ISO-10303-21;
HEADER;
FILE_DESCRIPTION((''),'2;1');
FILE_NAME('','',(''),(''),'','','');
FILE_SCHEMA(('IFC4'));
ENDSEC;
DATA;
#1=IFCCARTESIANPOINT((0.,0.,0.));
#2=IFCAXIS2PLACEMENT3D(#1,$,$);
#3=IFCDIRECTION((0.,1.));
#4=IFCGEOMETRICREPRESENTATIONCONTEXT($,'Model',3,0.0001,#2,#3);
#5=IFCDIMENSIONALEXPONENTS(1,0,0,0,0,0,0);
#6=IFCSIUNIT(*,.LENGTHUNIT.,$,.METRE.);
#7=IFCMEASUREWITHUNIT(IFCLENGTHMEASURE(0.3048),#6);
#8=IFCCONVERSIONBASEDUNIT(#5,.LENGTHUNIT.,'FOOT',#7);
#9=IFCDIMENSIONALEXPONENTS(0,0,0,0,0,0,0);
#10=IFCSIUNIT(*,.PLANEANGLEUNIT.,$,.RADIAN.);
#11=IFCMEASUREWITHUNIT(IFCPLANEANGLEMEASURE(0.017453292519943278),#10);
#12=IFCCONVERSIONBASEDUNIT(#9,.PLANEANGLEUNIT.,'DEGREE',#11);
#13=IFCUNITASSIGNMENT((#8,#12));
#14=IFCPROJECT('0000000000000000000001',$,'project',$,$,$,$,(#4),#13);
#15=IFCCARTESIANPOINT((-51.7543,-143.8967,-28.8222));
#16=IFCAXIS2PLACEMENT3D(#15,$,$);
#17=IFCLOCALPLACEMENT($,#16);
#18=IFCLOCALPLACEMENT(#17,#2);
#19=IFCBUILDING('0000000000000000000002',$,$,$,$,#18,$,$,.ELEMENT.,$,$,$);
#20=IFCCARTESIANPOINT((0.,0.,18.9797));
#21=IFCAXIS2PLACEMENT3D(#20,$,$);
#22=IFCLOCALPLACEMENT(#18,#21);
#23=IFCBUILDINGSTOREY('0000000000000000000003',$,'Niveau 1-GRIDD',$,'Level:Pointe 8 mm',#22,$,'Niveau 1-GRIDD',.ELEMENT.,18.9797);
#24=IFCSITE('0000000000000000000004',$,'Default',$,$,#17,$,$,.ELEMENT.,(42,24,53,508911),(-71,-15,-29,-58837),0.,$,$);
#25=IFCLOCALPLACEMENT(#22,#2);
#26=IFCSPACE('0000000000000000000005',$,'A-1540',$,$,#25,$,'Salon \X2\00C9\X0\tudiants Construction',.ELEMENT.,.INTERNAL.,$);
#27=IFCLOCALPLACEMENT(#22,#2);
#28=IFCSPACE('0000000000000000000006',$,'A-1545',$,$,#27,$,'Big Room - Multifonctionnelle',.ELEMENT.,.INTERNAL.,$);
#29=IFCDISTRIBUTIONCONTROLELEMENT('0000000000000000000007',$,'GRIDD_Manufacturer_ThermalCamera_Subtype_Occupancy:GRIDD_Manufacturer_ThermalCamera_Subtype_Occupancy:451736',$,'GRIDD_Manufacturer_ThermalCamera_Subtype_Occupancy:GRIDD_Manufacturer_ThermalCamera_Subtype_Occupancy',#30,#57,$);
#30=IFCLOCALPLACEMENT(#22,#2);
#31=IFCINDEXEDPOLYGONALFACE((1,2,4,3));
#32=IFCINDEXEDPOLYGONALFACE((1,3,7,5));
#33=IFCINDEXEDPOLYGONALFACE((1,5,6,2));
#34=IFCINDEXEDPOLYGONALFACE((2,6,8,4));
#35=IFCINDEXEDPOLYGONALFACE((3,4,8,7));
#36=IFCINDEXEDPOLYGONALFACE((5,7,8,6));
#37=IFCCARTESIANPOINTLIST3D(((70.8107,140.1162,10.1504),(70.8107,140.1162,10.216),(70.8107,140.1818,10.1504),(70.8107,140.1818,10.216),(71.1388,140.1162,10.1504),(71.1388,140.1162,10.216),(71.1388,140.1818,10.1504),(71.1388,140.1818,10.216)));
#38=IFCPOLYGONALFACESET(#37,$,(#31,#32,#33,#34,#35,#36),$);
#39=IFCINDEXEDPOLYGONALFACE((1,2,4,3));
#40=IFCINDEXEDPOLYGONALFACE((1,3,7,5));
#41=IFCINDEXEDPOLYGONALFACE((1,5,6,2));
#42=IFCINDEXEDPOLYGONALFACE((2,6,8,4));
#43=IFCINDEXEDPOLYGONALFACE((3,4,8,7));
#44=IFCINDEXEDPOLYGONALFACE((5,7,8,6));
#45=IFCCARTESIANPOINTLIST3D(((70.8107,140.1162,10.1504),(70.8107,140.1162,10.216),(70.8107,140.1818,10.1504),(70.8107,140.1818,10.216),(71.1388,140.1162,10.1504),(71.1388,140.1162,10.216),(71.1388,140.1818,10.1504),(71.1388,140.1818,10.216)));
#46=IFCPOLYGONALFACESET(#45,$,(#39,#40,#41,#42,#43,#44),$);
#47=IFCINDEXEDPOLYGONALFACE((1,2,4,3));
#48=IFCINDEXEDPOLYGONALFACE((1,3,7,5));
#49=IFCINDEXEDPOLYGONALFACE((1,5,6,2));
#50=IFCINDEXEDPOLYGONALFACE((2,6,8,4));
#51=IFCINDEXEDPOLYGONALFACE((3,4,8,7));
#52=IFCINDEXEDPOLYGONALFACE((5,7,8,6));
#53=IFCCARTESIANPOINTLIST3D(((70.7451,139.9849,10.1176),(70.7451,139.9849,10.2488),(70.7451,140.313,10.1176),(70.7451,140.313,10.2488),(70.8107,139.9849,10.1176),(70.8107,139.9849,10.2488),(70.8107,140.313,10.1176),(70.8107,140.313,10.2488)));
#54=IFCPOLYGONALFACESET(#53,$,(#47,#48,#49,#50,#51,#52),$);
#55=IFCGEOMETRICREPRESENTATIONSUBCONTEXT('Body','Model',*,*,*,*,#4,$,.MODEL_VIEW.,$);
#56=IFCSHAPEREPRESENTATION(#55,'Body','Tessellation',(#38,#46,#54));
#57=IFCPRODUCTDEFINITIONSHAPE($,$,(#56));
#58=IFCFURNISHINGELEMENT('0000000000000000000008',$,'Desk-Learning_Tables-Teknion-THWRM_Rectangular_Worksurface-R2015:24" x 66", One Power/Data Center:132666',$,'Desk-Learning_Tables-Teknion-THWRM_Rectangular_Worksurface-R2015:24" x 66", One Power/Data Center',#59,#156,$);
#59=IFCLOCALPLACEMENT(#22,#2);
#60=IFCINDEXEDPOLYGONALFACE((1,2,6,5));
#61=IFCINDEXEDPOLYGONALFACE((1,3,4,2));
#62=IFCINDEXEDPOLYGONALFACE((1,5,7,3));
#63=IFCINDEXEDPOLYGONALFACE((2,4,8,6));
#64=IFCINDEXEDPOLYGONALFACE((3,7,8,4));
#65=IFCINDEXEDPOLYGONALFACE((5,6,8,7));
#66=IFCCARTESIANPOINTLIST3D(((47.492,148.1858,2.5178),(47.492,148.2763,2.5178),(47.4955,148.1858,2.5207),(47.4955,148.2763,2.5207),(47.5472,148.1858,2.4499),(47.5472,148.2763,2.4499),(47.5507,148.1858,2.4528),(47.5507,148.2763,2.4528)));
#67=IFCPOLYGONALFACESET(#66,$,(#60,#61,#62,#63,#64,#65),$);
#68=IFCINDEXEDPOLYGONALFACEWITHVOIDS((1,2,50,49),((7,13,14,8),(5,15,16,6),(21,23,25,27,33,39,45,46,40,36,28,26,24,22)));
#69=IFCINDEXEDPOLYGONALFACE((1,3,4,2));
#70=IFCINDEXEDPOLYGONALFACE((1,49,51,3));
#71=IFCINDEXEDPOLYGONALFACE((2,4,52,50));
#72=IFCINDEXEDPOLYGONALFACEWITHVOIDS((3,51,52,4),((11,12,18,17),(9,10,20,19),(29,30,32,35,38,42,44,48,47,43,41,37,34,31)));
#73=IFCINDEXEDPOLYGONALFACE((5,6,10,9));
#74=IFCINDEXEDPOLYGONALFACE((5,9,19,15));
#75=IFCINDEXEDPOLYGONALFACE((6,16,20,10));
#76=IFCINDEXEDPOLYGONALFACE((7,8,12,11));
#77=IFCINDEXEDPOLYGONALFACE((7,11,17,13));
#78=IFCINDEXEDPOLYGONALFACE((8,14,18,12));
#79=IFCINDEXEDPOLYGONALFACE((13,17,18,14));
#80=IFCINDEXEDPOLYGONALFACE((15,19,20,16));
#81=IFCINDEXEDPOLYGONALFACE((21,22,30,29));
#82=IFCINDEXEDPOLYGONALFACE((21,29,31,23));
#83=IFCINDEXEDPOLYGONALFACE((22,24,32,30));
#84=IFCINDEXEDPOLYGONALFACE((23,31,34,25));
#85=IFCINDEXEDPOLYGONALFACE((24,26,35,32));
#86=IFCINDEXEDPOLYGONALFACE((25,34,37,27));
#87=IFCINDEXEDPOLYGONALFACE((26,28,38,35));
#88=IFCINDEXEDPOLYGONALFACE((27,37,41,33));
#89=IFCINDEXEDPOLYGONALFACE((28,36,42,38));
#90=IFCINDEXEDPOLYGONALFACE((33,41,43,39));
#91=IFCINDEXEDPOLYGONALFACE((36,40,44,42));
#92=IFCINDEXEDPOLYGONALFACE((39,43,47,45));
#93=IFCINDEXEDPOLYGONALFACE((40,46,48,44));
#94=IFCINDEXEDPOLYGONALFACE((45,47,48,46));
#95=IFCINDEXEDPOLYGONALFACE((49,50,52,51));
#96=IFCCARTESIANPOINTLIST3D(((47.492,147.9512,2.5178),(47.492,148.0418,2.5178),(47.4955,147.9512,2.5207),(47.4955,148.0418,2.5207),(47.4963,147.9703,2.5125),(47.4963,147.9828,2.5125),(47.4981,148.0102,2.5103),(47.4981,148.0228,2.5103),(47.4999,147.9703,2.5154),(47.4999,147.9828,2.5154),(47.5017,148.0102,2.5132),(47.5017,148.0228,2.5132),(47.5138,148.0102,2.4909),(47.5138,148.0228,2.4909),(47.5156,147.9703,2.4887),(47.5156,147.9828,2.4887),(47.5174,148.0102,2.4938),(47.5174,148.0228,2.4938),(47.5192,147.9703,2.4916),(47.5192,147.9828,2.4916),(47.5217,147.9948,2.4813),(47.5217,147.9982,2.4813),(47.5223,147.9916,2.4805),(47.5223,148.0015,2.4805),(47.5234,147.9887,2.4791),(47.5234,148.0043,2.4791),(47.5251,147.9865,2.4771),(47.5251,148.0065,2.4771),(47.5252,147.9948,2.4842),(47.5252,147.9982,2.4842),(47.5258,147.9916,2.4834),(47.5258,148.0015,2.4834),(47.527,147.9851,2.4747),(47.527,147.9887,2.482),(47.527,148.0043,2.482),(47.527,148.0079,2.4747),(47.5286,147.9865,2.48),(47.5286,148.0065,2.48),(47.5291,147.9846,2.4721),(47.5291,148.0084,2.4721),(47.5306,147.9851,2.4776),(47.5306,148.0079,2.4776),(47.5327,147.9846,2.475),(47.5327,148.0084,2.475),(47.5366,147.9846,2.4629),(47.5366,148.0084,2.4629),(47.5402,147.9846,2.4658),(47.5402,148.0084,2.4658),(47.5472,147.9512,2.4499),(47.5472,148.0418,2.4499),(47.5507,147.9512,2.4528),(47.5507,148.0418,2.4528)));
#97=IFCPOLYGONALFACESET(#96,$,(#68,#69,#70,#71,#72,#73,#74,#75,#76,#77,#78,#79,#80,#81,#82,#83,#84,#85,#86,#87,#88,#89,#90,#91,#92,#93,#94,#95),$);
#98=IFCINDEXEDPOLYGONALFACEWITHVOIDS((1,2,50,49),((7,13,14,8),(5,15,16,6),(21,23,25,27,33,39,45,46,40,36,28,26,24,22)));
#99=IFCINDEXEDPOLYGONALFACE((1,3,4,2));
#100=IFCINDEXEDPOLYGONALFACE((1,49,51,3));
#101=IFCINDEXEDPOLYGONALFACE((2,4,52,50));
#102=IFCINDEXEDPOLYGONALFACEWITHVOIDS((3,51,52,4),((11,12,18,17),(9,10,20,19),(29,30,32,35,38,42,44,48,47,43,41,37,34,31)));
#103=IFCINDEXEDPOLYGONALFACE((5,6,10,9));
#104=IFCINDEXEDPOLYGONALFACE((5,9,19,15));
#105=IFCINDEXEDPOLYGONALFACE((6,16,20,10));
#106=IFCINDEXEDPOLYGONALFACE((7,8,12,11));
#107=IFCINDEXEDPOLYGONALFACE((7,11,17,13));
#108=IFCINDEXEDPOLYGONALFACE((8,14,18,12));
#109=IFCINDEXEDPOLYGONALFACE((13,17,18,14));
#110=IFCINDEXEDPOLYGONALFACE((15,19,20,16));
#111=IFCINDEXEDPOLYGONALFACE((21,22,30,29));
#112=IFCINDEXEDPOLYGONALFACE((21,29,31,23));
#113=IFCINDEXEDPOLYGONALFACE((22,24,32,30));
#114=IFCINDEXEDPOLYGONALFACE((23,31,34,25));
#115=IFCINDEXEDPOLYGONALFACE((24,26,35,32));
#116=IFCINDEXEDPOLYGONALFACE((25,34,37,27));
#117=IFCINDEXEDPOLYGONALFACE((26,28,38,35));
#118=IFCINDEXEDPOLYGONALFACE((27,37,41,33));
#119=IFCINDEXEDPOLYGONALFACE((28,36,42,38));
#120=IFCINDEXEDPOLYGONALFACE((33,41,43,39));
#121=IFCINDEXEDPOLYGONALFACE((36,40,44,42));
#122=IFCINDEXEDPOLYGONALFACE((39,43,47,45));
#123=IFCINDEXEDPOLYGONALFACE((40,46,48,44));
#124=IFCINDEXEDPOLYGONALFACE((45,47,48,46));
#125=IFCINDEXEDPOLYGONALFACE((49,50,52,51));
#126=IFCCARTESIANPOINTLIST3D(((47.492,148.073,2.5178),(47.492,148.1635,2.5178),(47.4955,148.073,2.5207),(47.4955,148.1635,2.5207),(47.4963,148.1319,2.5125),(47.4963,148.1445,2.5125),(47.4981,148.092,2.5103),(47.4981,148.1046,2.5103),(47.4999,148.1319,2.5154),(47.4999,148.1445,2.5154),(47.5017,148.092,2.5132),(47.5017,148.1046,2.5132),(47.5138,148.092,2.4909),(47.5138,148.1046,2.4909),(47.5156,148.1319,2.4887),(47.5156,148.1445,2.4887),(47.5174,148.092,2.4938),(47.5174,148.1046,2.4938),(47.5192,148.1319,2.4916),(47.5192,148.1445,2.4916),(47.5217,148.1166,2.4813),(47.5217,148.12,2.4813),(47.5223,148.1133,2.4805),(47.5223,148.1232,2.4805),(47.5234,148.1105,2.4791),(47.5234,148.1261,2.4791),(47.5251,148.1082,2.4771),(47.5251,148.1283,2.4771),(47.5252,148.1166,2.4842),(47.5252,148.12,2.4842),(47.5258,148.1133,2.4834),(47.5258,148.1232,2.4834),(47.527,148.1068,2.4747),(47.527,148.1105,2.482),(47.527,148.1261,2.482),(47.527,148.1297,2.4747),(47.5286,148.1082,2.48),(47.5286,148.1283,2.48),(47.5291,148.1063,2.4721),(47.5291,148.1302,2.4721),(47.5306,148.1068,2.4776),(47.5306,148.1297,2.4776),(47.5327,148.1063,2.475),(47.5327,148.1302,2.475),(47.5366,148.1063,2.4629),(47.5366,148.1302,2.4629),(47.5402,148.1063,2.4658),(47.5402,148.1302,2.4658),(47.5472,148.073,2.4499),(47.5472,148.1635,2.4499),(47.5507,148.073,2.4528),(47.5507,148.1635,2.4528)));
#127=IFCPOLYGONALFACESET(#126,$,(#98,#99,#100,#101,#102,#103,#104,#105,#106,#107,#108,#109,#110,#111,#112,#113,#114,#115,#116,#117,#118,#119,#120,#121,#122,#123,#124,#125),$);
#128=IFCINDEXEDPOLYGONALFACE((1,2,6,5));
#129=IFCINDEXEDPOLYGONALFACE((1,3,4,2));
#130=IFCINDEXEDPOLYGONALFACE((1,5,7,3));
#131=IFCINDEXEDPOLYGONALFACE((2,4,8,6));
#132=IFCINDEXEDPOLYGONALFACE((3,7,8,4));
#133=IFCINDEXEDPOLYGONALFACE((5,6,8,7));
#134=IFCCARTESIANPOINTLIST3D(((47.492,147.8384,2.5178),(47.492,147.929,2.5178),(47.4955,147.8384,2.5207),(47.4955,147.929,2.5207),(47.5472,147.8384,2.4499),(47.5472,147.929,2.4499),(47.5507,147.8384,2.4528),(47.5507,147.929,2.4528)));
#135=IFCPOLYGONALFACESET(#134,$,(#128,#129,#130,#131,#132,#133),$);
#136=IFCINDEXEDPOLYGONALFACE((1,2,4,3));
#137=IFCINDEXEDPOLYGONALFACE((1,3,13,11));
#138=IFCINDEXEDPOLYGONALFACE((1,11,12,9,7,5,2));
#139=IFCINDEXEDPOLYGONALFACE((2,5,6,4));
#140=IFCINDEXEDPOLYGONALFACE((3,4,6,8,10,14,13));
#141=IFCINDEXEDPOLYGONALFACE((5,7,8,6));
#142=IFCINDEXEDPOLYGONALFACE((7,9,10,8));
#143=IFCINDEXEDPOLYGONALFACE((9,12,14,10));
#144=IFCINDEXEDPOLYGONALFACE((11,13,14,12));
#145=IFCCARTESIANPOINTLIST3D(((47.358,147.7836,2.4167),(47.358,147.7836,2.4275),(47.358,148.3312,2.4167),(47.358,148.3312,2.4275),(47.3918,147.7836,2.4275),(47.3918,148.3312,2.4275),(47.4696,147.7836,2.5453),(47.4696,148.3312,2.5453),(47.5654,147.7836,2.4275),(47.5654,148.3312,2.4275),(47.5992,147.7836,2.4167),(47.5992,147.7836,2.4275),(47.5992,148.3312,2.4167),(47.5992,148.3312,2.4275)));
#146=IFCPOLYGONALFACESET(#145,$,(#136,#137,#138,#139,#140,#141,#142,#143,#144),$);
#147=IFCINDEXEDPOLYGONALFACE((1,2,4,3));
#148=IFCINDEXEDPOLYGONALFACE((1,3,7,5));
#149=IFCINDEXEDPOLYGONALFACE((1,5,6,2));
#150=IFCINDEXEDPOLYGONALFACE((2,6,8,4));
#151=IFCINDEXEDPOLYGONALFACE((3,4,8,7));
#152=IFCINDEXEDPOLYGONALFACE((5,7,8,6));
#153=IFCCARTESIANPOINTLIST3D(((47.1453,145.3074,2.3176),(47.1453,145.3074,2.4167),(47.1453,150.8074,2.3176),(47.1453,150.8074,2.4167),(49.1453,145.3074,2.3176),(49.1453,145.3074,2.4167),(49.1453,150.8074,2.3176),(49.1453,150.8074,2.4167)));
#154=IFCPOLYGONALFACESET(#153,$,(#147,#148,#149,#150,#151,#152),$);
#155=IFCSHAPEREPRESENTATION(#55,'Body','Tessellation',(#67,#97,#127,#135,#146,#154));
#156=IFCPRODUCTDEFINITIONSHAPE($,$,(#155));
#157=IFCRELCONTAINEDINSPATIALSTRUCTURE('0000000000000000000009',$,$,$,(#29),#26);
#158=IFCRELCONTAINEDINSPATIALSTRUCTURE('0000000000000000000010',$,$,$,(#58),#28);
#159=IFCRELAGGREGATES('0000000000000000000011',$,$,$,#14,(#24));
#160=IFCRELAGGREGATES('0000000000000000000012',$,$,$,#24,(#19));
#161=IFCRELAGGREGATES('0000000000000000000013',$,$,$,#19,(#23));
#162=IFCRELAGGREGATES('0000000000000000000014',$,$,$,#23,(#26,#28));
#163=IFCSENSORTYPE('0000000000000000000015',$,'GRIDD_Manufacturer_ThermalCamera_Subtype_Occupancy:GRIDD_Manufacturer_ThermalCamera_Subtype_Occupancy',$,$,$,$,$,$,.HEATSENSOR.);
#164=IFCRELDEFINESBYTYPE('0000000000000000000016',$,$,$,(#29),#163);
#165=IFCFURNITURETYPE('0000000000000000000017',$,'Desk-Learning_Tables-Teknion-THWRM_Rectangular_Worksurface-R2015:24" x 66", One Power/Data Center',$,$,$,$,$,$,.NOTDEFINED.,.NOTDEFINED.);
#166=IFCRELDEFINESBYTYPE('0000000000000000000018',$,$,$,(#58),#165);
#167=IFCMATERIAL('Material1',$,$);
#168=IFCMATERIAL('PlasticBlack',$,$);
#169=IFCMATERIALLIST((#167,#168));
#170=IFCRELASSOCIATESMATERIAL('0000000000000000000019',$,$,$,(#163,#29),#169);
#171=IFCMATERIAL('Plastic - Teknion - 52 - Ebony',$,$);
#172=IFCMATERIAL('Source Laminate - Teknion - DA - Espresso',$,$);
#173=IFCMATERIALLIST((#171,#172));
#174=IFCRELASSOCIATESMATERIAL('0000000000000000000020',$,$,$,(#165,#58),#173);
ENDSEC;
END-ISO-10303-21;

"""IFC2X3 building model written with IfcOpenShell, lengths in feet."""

from ifc_helpers import new_model, entity, si_unit, converted_unit, direction, frame, frame_2d, origin, origin_2d_with_axis, place, context, subcontext, project, spatial, polyline, circle_curve, parameter, trimmed, segment, composite_curve, rectangle, outline, extrude, source, transform, mapped, material, material_list, type_object, type_shapes, element, save


model = new_model("IFC2X3")

# Units and contexts
model_context = context("Model", 3, precision=0.0001, world=origin(), true_north=direction((0.0, 1.0)))
body_context = subcontext(model_context, "Body", "Model", "MODEL_VIEW")
ifc_project = project(units=[converted_unit("LENGTHUNIT", "FOOT", entity("IfcLengthMeasure", 0.3048), si_unit("LENGTHUNIT", "METRE"), dimensions=[1, 0, 0, 0, 0, 0, 0]), converted_unit("PLANEANGLEUNIT", "DEGREE", entity("IfcPlaneAngleMeasure", 0.017453292519943278), si_unit("PLANEANGLEUNIT", "RADIAN"), dimensions=[0, 0, 0, 0, 0, 0, 0])], contexts=[model_context])

# Site, building, storey
site_placement = place(None, frame((-51.7543, -143.8967, -28.8222)))
site = spatial("IfcSite", under=ifc_project, at=site_placement, Name="Default", CompositionType="ELEMENT", RefLatitude=(42, 24, 53, 508911), RefLongitude=(-71, -15, -29, -58837), RefElevation=0.0)
building_placement = place(site_placement, origin())
building = spatial("IfcBuilding", under=site, at=building_placement, CompositionType="ELEMENT")
storey_placement = place(building_placement, frame((0.0, 0.0, 18.9797)))
storey = spatial("IfcBuildingStorey", under=building, at=storey_placement, Name="Niveau 1-GRIDD", ObjectType="Level:Pointe 8 mm", LongName="Niveau 1-GRIDD", CompositionType="ELEMENT", Elevation=18.9797)

# Shared definitions
space_1_placement = place(storey_placement, origin())
space_1 = spatial("IfcSpace", under=storey, at=space_1_placement, Name="A-1540", LongName="Salon Étudiants Construction", CompositionType="ELEMENT", InteriorOrExteriorSpace="INTERNAL")

# Distribution control element
ifc_material_1 = material(Name="Material1")
ifc_material_2 = material(Name="PlasticBlack")
ifc_material_list_1 = material_list([ifc_material_1, ifc_material_2])
sensor_type = type_object("IfcSensorType", Name="GRIDD_Manufacturer_ThermalCamera_Subtype_Occupancy:GRIDD_Manufacturer_ThermalCamera_Subtype_Occupancy", PredefinedType="HEATSENSOR", material=ifc_material_list_1)
shared_shape_1 = source(origin(), body_context, "Body", "SweptSolid", [
    extrude(rectangle(XDim=0.0656, YDim=0.0656, at=origin_2d_with_axis()), frame((0.0, 0.0, 0.0), z_axis=(0.0, 0.0, 1.0), x_axis=(-1.0, 0.0, 0.0)), (0.0, 0.0, 1.0), 0.3281),
    extrude(rectangle(XDim=0.0656, YDim=0.0656, at=origin_2d_with_axis()), frame((0.0, 0.0, 0.0), z_axis=(0.0, 0.0, 1.0), x_axis=(-1.0, 0.0, 0.0)), (0.0, 0.0, 1.0), 0.3281),
    extrude(rectangle(XDim=0.3281, YDim=0.1312, at=frame_2d((0.0, 0.0), x_axis=(1.0, 0.0))), frame((0.0, 0.0, 0.3281)), (0.0, 0.0, 1.0), 0.0656),
])
type_shapes(sensor_type, [shared_shape_1])
distribution_control_element_placement = place(space_1_placement, frame((71.1388, 140.149, 10.1832), z_axis=(-1.0, 0.0, 0.0), x_axis=(0.0, 1.0, 0.0)))
element("IfcDistributionControlElement", 1, at=distribution_control_element_placement, inside=space_1, type_object=sensor_type, material=ifc_material_list_1, Name="GRIDD_Manufacturer_ThermalCamera_Subtype_Occupancy:GRIDD_Manufacturer_ThermalCamera_Subtype_Occupancy:451736", ObjectType="GRIDD_Manufacturer_ThermalCamera_Subtype_Occupancy:GRIDD_Manufacturer_ThermalCamera_Subtype_Occupancy", context=body_context, shape_type="MappedRepresentation", body=[
    mapped(shared_shape_1, transform((0.0, 0.0, 0.0), scale=1.0)),
])

# Shared definitions
space_2_placement = place(storey_placement, origin())
space_2 = spatial("IfcSpace", under=storey, at=space_2_placement, Name="A-1545", LongName="Big Room - Multifonctionnelle", CompositionType="ELEMENT", InteriorOrExteriorSpace="INTERNAL")

# Furnishing element
ifc_material_3 = material(Name="Plastic - Teknion - 52 - Ebony")
ifc_material_4 = material(Name="Source Laminate - Teknion - DA - Espresso")
ifc_material_list_2 = material_list([ifc_material_3, ifc_material_4])
furniture_type_1 = type_object("IfcFurnitureType", Name="Desk-Learning_Tables-Teknion-THWRM_Rectangular_Worksurface-R2015:24\" x 66\", One Power/Data Center", AssemblyPlace="NOTDEFINED", material=ifc_material_list_2)
shared_shape_2 = source(origin(), body_context, "Body", "SweptSolid", [
    extrude(rectangle(XDim=0.0875, YDim=0.0046, at=frame_2d((0.0, 0.0), x_axis=(0.0, 1.0))), frame((0.1284, 0.6239, 2.4853), z_axis=(1.0, 0.0, 0.0), x_axis=(0.0, 0.776046, -0.630676)), (0.0, 0.0, 1.0), 0.0906),
    extrude(outline(polyline([(-0.0453, -0.0438), (0.0453, -0.0438), (0.0453, 0.0438), (-0.0453, 0.0438), (-0.0453, -0.0438)]), holes=[polyline([(-0.0262, -0.0063), (-0.0137, -0.0063), (-0.0137, -0.0369), (-0.0262, -0.0369), (-0.0262, -0.0063)]), polyline([(0.0137, -0.0341), (0.0137, -0.0091), (0.0262, -0.0091), (0.0262, -0.0341), (0.0137, -0.0341)]), composite_curve([segment(polyline([(-0.0119, 0.027), (0.0119, 0.027)]), True, "CONTINUOUS"), segment(polyline([(0.0119, 0.027), (0.0119, 0.0151)]), True, "CONTINUOUS"), segment(trimmed(circle_curve(frame_2d((0.0, 0.0151), x_axis=(0.0, -1.0)), 0.0119), [parameter(270.0)], [parameter(90.0)], True, "PARAMETER"), False, "CONTINUOUS"), segment(polyline([(-0.0119, 0.0151), (-0.0119, 0.027)]), True, "CONTINUOUS")], self_intersect=False)]), frame((-0.0609, 0.6221, 2.4867), z_axis=(0.0, 0.776046, -0.630676), x_axis=(1.0, 0.0, 0.0)), (0.0, 0.0, 1.0), 0.0046),
    extrude(outline(polyline([(-0.0438, -0.0453), (0.0438, -0.0453), (0.0438, 0.0453), (-0.0438, 0.0453), (-0.0438, -0.0453)]), holes=[polyline([(-0.0063, -0.0262), (-0.0369, -0.0262), (-0.0369, -0.0137), (-0.0063, -0.0137), (-0.0063, -0.0262)]), polyline([(-0.0341, 0.0137), (-0.0341, 0.0262), (-0.0091, 0.0262), (-0.0091, 0.0137), (-0.0341, 0.0137)]), composite_curve([segment(polyline([(0.027, -0.0119), (0.0151, -0.0119)]), True, "CONTINUOUS"), segment(trimmed(circle_curve(frame_2d((0.0151, 0.0), x_axis=(-1.0, 0.0)), 0.0119), [parameter(270.0)], [parameter(90.0)], True, "PARAMETER"), False, "CONTINUOUS"), segment(polyline([(0.0151, 0.0119), (0.027, 0.0119)]), True, "CONTINUOUS"), segment(polyline([(0.027, 0.0119), (0.027, -0.0119)]), True, "CONTINUOUS")], self_intersect=False)]), frame((0.0609, 0.6221, 2.4867), z_axis=(0.0, 0.776046, -0.630676), x_axis=(0.0, -0.630676, -0.776046)), (0.0, 0.0, 1.0), 0.0046),
    extrude(rectangle(XDim=0.0875, YDim=0.0046, at=frame_2d((0.0, 0.0), x_axis=(0.0, 1.0))), frame((-0.219, 0.6239, 2.4853), z_axis=(1.0, 0.0, 0.0), x_axis=(0.0, 0.776046, -0.630676)), (0.0, 0.0, 1.0), 0.0906),
    extrude(outline(polyline([(-0.0586, -0.0638), (0.0826, -0.0638), (0.0371, 0.0811), (0.0557, 0.1093), (0.0467, 0.1152), (-0.0862, -0.086), (-0.0772, -0.092), (-0.0586, -0.0638)])), frame((-0.2738, 0.6679, 2.4412), z_axis=(1.0, 0.0, 0.0), x_axis=(0.0, -0.551103, 0.834437)), (0.0, 0.0, 1.0), 0.5475),
    extrude(rectangle(XDim=5.5, YDim=2.0, at=frame_2d((0.0, 0.0), x_axis=(1.0, 0.0))), frame((0.0, 0.0, 2.3176), z_axis=(0.0, 0.0, 1.0), x_axis=(-1.0, 0.0, 0.0)), (0.0, 0.0, 1.0), 0.0991),
])
type_shapes(furniture_type_1, [shared_shape_2])
for number, where, z_axis, x_axis, name in (
    (2, (48.1453, 148.0574, 0.0), (0.0, 0.0, 1.0), (0.0, 1.0, 0.0), "Desk-Learning_Tables-Teknion-THWRM_Rectangular_Worksurface-R2015:24\" x 66\", One Power/Data Center:132666"),
):
    element("IfcFurnishingElement", number, at=place(space_2_placement, frame(where, z_axis=z_axis, x_axis=x_axis)), inside=space_2, type_object=furniture_type_1, material=ifc_material_list_2, Name=name, ObjectType="Desk-Learning_Tables-Teknion-THWRM_Rectangular_Worksurface-R2015:24\" x 66\", One Power/Data Center", context=body_context, shape_type="MappedRepresentation", body=[
        mapped(shared_shape_2, transform((0.0, 0.0, 0.0), scale=1.0)),
    ])

save(model, "model.ifc")
